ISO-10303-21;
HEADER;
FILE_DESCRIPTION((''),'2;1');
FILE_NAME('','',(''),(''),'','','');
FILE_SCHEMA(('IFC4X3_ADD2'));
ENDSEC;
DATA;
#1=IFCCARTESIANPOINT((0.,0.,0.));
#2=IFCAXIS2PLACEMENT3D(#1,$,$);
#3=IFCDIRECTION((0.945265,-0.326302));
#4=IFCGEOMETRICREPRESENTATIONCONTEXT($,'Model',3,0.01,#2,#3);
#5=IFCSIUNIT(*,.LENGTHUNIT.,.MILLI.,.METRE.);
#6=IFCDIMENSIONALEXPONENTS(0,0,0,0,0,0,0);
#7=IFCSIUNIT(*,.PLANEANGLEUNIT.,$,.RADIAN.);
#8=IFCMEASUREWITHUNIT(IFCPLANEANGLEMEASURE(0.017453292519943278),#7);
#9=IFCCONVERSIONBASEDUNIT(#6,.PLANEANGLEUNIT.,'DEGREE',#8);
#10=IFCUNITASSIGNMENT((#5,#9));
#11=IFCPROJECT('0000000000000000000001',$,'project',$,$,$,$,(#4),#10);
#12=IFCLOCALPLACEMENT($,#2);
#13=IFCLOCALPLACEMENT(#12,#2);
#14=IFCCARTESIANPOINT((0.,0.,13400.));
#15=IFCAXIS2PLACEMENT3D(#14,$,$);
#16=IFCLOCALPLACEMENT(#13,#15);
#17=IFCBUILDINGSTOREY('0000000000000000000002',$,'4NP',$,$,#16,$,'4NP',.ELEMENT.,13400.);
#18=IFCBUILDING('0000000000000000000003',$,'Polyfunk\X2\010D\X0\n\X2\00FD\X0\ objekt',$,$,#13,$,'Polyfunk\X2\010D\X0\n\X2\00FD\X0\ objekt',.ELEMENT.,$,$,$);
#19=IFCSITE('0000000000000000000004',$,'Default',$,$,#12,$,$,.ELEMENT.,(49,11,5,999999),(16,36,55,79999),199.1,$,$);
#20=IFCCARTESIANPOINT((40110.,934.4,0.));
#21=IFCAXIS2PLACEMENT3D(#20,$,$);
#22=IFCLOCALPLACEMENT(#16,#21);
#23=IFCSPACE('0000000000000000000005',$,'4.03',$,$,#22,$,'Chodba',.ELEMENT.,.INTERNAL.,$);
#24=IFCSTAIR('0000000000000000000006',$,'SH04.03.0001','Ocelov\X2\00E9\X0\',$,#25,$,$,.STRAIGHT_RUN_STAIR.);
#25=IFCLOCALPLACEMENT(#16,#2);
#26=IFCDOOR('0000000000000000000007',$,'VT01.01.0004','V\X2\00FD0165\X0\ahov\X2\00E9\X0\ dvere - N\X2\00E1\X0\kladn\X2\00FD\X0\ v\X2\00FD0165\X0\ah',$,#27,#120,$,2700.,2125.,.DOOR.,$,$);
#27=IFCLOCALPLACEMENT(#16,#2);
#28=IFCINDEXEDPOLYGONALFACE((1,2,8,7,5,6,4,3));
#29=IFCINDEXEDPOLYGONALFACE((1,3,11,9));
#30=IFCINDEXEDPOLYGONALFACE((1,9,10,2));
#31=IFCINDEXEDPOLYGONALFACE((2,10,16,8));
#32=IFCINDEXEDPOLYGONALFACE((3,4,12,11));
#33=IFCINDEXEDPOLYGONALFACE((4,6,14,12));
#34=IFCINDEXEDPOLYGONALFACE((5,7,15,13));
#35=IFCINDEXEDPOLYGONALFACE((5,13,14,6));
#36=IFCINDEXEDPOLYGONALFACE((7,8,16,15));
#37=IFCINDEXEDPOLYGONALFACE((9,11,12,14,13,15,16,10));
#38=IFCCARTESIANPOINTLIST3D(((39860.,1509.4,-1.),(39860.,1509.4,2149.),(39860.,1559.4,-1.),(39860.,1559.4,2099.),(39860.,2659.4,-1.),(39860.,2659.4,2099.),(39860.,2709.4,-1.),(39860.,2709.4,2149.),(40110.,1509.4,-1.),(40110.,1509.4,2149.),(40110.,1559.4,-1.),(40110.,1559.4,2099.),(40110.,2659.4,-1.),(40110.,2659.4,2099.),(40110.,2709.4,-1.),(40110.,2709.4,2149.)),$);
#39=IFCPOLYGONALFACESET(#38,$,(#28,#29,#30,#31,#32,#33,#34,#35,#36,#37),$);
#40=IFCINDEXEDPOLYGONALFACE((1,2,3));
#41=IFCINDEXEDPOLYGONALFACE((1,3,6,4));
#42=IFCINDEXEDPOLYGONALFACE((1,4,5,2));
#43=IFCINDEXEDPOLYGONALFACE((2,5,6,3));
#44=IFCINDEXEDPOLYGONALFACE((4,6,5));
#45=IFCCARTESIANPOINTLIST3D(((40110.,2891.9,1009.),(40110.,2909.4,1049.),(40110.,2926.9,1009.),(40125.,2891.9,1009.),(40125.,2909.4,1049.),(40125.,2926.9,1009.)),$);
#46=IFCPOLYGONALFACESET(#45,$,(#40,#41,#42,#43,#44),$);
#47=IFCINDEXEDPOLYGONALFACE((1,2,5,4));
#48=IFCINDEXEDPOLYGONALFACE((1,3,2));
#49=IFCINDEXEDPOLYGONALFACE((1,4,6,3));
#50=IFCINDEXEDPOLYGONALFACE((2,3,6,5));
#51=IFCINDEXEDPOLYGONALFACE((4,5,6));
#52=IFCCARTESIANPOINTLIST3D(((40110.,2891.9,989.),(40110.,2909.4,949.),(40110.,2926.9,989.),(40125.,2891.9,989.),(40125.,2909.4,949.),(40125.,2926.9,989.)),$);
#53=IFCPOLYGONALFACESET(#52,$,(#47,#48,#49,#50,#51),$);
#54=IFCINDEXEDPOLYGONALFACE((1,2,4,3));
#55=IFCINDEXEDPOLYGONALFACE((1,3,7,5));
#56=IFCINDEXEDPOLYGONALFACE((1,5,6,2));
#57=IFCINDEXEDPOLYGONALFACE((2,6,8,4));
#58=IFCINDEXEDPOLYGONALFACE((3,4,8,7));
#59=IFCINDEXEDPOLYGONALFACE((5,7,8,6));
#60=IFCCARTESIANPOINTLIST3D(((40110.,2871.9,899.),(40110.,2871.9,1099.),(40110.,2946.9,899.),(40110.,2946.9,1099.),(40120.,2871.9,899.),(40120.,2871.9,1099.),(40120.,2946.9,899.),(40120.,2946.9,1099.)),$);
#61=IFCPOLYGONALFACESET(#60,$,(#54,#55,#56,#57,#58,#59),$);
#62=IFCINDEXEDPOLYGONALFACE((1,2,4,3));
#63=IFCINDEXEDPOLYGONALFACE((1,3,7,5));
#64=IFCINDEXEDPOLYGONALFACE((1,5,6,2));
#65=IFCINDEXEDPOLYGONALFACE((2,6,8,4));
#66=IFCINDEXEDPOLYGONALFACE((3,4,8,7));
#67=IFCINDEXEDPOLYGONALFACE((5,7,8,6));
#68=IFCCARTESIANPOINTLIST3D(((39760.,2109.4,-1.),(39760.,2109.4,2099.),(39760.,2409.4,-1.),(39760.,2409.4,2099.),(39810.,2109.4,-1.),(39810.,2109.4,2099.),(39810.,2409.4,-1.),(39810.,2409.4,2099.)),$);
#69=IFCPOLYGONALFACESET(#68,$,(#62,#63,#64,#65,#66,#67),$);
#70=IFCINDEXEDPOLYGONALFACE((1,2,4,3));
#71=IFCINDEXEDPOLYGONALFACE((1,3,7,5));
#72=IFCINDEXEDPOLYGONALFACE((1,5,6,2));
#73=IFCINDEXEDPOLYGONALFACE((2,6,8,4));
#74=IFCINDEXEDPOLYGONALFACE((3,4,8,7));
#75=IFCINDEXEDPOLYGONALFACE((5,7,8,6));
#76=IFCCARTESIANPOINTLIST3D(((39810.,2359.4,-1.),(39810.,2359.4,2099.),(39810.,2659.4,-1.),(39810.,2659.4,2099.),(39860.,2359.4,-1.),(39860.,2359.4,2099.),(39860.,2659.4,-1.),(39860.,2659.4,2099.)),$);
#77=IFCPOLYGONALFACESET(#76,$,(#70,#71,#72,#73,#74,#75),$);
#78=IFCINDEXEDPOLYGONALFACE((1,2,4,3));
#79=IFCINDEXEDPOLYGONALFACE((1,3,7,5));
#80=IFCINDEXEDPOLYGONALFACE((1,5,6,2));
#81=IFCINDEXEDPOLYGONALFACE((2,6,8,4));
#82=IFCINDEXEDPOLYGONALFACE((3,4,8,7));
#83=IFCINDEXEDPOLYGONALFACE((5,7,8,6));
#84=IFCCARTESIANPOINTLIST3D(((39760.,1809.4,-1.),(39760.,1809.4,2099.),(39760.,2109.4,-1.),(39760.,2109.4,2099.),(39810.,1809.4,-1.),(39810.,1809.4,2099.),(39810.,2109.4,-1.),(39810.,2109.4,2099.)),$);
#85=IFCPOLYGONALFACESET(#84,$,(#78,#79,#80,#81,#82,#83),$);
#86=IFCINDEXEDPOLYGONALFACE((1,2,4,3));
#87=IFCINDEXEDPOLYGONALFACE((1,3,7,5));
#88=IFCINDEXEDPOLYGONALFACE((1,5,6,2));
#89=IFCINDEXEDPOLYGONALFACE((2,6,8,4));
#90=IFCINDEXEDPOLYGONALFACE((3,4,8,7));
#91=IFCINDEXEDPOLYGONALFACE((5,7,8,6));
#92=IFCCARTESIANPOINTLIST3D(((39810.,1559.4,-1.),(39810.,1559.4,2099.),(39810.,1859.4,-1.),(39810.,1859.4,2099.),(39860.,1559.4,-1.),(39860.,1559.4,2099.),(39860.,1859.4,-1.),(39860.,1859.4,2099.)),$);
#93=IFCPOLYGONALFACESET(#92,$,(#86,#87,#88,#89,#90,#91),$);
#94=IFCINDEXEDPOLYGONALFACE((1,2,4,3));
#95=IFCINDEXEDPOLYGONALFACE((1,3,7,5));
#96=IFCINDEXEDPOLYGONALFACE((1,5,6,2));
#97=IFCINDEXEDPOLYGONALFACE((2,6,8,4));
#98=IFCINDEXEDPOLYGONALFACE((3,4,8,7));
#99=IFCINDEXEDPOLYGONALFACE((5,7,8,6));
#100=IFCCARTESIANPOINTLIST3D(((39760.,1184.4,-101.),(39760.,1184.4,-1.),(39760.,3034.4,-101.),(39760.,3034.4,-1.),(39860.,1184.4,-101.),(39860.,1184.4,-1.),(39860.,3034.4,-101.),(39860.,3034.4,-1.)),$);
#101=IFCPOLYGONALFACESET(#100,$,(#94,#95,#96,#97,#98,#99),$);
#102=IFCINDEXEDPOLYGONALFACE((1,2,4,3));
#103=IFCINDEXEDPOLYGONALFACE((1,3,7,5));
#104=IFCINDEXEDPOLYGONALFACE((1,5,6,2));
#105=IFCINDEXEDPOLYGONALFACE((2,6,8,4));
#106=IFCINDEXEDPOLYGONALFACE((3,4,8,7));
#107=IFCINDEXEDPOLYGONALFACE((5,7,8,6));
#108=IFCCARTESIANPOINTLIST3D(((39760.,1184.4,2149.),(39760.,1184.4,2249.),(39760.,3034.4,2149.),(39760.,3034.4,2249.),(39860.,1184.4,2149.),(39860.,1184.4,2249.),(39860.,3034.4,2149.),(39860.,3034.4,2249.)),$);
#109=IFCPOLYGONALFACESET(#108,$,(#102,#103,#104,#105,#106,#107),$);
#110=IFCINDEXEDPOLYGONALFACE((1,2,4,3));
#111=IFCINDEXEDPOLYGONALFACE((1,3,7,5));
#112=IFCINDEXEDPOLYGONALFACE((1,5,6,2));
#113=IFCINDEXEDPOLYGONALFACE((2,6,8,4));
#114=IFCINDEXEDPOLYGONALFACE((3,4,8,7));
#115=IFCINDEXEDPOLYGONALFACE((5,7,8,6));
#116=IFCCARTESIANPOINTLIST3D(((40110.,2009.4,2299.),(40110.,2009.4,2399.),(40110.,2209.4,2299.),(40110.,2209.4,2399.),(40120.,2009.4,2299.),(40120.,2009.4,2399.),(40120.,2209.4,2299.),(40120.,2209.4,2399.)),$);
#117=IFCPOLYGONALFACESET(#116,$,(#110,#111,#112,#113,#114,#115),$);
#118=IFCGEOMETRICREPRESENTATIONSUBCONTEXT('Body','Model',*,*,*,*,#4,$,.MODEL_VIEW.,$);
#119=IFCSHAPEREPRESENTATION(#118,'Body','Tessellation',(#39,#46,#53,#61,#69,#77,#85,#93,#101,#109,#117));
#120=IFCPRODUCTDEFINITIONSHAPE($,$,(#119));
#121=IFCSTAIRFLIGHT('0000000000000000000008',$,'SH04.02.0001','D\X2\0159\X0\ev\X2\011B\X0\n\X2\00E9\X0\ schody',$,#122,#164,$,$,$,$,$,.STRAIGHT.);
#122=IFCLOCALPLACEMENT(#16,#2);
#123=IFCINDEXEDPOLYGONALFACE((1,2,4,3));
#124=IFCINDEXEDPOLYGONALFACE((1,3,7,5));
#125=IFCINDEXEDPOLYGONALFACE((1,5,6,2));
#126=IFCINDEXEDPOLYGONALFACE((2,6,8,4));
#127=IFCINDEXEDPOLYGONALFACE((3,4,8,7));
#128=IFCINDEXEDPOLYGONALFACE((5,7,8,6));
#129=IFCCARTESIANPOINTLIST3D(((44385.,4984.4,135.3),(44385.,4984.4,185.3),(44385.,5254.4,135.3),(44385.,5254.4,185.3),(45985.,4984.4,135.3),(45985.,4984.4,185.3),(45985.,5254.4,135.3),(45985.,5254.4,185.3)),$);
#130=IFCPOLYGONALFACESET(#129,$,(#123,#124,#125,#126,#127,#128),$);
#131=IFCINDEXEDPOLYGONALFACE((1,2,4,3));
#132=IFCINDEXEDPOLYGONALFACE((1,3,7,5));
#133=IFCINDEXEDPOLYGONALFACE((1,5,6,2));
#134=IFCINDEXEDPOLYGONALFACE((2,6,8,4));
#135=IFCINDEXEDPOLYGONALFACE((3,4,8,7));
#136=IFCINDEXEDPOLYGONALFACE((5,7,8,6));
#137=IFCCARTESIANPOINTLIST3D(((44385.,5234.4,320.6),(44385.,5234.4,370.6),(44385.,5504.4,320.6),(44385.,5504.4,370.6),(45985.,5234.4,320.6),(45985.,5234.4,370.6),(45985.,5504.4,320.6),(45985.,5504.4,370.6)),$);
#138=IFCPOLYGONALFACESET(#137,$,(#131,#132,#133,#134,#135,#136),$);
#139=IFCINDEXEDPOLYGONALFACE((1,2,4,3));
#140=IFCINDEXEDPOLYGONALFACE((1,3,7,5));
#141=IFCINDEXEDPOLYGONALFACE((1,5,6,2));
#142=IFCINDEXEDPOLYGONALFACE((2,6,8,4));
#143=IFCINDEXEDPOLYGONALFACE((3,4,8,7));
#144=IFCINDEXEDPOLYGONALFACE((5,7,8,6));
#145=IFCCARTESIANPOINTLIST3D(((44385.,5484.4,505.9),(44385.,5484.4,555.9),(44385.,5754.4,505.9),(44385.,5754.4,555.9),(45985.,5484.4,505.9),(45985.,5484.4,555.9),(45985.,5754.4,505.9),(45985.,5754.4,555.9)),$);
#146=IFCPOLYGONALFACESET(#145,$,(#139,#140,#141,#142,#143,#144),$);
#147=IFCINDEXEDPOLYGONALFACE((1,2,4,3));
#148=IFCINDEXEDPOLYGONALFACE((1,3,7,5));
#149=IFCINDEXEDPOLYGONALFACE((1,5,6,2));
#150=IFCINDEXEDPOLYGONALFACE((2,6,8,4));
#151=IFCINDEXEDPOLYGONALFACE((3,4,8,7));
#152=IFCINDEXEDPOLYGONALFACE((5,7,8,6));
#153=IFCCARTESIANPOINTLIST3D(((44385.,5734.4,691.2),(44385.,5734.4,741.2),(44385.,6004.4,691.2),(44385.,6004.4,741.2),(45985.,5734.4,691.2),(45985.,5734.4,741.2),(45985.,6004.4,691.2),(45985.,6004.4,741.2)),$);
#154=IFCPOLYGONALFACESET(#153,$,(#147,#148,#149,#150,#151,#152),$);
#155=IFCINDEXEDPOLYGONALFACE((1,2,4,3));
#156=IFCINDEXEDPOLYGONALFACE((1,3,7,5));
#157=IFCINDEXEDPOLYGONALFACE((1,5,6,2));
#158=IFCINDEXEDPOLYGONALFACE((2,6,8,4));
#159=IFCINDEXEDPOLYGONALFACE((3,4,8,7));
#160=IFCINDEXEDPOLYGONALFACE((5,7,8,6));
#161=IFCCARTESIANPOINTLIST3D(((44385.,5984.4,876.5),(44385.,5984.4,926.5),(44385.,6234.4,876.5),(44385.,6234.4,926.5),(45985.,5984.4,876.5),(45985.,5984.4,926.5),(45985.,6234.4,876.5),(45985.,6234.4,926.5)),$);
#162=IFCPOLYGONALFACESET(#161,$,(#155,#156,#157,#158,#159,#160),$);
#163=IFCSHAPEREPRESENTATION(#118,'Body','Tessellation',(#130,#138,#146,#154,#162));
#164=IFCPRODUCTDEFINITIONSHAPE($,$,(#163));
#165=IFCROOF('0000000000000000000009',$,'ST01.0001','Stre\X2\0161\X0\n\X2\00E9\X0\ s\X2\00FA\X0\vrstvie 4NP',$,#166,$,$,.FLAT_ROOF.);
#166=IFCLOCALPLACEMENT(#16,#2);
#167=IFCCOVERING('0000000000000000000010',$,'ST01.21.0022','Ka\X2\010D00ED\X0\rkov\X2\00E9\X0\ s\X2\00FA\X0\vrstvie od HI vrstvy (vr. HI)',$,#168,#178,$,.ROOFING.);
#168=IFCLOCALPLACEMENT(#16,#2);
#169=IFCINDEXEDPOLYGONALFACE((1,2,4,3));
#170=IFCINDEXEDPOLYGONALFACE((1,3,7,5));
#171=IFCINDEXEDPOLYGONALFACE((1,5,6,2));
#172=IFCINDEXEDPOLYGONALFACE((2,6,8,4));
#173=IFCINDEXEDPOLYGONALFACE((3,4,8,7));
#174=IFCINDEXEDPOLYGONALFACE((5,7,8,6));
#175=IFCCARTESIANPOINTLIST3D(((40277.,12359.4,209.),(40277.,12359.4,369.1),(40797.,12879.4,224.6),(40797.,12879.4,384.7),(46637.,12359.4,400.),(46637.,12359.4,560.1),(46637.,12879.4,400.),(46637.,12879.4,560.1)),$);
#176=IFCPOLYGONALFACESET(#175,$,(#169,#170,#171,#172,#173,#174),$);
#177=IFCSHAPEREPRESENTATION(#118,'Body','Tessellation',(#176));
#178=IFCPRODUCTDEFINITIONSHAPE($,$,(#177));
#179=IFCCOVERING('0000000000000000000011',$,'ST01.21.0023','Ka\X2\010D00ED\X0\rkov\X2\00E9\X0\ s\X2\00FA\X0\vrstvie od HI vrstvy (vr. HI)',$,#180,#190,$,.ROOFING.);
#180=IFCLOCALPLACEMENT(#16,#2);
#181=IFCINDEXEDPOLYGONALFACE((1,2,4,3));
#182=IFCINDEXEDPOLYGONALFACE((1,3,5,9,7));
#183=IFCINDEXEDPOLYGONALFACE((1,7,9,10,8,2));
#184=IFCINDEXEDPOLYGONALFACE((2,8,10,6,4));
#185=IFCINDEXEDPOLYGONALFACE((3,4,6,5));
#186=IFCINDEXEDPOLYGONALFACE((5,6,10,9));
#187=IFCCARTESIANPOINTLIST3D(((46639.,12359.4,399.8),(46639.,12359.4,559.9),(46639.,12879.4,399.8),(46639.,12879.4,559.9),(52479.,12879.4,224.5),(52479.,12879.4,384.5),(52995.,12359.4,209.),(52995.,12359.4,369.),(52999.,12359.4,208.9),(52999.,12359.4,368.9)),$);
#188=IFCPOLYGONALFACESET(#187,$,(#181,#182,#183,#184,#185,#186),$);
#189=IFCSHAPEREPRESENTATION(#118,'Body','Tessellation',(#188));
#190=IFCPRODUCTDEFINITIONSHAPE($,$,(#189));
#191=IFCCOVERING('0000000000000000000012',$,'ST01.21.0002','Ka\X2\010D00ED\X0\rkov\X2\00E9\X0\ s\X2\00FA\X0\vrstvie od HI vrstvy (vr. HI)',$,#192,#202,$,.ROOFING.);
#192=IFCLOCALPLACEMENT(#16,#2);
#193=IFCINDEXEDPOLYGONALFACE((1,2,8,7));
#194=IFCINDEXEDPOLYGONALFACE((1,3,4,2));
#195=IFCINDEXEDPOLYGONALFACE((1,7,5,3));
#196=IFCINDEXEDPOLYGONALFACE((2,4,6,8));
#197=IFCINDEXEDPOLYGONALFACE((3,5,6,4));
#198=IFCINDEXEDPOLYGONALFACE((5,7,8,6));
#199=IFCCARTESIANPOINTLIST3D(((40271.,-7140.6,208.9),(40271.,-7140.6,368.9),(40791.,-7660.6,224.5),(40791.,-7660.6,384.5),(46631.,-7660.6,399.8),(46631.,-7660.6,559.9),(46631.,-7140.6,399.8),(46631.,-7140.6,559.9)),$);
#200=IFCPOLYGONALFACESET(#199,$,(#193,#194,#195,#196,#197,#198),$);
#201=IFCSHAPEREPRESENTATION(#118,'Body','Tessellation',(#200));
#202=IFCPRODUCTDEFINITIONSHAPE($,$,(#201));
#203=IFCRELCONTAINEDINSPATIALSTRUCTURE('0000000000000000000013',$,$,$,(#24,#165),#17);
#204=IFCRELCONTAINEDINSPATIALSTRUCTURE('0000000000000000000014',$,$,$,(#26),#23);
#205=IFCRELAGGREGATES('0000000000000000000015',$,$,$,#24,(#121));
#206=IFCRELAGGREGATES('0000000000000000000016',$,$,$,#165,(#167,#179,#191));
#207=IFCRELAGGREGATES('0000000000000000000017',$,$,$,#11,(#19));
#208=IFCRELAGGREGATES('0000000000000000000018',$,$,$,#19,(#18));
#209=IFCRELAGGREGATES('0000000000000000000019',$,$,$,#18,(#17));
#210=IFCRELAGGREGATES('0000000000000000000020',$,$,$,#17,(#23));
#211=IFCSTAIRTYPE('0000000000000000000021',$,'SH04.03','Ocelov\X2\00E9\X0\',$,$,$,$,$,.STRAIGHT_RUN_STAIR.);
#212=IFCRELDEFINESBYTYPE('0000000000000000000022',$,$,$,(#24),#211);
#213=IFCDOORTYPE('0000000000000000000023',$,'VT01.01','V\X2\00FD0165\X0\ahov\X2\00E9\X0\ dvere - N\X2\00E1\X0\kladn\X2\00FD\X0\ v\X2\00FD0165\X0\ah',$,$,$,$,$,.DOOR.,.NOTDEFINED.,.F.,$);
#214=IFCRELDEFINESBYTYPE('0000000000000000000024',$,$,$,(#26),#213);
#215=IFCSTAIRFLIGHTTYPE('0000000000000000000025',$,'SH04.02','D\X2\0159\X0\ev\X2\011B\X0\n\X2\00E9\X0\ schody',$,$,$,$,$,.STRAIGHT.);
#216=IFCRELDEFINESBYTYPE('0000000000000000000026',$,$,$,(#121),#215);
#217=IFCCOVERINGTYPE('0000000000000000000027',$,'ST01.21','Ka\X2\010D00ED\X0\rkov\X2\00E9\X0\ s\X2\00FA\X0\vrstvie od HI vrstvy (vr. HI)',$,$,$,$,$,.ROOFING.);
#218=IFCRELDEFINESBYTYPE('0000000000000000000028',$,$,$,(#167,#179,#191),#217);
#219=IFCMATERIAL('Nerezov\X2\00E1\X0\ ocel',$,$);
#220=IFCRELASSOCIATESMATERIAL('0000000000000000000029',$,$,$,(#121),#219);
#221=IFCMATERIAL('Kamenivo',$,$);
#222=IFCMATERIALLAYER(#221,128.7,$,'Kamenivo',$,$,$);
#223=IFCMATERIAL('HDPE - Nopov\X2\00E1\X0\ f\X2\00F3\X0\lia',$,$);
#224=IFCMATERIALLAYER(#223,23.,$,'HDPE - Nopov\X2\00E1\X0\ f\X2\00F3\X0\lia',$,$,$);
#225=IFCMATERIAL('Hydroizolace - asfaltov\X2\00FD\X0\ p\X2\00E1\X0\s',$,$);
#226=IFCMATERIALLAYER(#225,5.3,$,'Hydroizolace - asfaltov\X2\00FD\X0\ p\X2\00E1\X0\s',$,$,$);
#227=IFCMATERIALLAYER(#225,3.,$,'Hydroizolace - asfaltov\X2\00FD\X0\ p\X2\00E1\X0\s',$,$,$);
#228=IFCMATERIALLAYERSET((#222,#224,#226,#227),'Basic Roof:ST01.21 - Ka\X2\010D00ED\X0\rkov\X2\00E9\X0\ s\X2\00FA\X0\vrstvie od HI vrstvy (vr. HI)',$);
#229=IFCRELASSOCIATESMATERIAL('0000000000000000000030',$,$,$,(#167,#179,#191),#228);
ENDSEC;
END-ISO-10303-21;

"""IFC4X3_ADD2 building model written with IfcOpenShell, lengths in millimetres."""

from ifc_helpers import new_model, entity, si_unit, converted_unit, direction, frame, frame_2d, origin, origin_2d_with_axis, place, context, subcontext, project, spatial, polyline, rectangle, outline, extrude, source, transform, mapped, material, layer, layer_set, type_object, type_shapes, element, aggregate, save


model = new_model("IFC4X3_ADD2")

# Units and contexts
model_context = context("Model", 3, precision=0.01, world=origin(), true_north=direction((0.945265, -0.326302)))
body_context = subcontext(model_context, "Body", "Model", "MODEL_VIEW")
ifc_project = project(units=[si_unit("LENGTHUNIT", "METRE", prefix="MILLI"), converted_unit("PLANEANGLEUNIT", "DEGREE", entity("IfcPlaneAngleMeasure", 0.017453292519943278), si_unit("PLANEANGLEUNIT", "RADIAN"), dimensions=[0, 0, 0, 0, 0, 0, 0])], contexts=[model_context])

# Site, building, storey
site_placement = place(None, origin())
site = spatial("IfcSite", under=ifc_project, at=site_placement, Name="Default", CompositionType="ELEMENT", RefLatitude=(49, 11, 5, 999999), RefLongitude=(16, 36, 55, 79999), RefElevation=199.1)
building_placement = place(site_placement, origin())
building = spatial("IfcBuilding", under=site, at=building_placement, Name="Polyfunkčný objekt", LongName="Polyfunkčný objekt", CompositionType="ELEMENT")
storey_placement = place(building_placement, frame((0.0, 0.0, 13400.0)))
storey = spatial("IfcBuildingStorey", under=building, at=storey_placement, Name="4NP", LongName="4NP", CompositionType="ELEMENT", Elevation=13400.0)

# Shared definitions
ifc_material_1 = material(Name="Nerezová ocel")

# Stair
stair_type = type_object("IfcStairType", Name="SH04.03", Description="Ocelové", PredefinedType="STRAIGHT_RUN_STAIR")
stair_placement = place(storey_placement, origin())
stair = element("IfcStair", 1, at=stair_placement, inside=storey, type_object=stair_type, Name="SH04.03.0001", Description="Ocelové", PredefinedType="STRAIGHT_RUN_STAIR")

# Shared definitions
space_placement = place(storey_placement, frame((40110.0, 934.4, 0.0)))
space = spatial("IfcSpace", under=storey, at=space_placement, Name="4.03", LongName="Chodba", CompositionType="ELEMENT", PredefinedType="INTERNAL")

# Door
door_type_1 = type_object("IfcDoorType", Name="VT01.01", Description="Výťahové dvere - Nákladný výťah", OperationType="NOTDEFINED", ParameterTakesPrecedence=False, PredefinedType="DOOR")
shared_shape_1 = source(origin(), body_context, "Body", "SweptSolid", [
    extrude(outline(polyline([(-1087.5, -600.0), (1062.5, -600.0), (1062.5, -550.0), (-1037.5, -550.0), (-1037.5, 550.0), (1062.5, 550.0), (1062.5, 600.0), (-1087.5, 600.0), (-1087.5, -600.0)])), frame((600.0, 0.0, 1062.5), z_axis=(0.0, 1.0, 0.0), x_axis=(0.0, 0.0, -1.0)), (0.0, 0.0, 1.0), 250.0),
    extrude(outline(polyline([(-24.4, -10.7), (19.2, -10.7), (5.2, 21.4), (-24.4, -10.7)])), frame((1400.0, -15.0, 1023.3), z_axis=(0.0, 1.0, 0.0), x_axis=(0.400819, 0.0, -0.916157)), (0.0, 0.0, 1.0), 15.0),
    extrude(outline(polyline([(-24.4, -10.7), (19.2, -10.7), (5.2, 21.4), (-24.4, -10.7)])), frame((1400.0, -15.0, 976.7), z_axis=(0.0, 1.0, 0.0), x_axis=(-0.400819, 0.0, 0.916157)), (0.0, 0.0, 1.0), 15.0),
    extrude(rectangle(XDim=10.0, YDim=75.0, at=frame_2d((0.0, 0.0), x_axis=(1.0, 0.0))), frame((1400.0, -5.0, 900.0), z_axis=(0.0, 0.0, 1.0), x_axis=(0.0, 1.0, 0.0)), (0.0, 0.0, 1.0), 200.0),
    extrude(rectangle(XDim=50.0, YDim=300.0, at=origin_2d_with_axis()), frame((750.0, 325.0, 0.0), z_axis=(0.0, 0.0, 1.0), x_axis=(0.0, -1.0, 0.0)), (0.0, 0.0, 1.0), 2100.0),
    extrude(rectangle(XDim=50.0, YDim=300.0, at=frame_2d((0.0, 0.0), x_axis=(1.0, 0.0))), frame((1000.0, 275.0, 0.0), z_axis=(0.0, 0.0, 1.0), x_axis=(0.0, -1.0, 0.0)), (0.0, 0.0, 1.0), 2100.0),
    extrude(rectangle(XDim=300.0, YDim=50.0, at=frame_2d((0.0, 0.0), x_axis=(1.0, 0.0))), frame((450.0, 325.0, 0.0), z_axis=(0.0, 0.0, 1.0), x_axis=(-1.0, 0.0, 0.0)), (0.0, 0.0, 1.0), 2100.0),
    extrude(rectangle(XDim=300.0, YDim=50.0, at=frame_2d((0.0, 0.0), x_axis=(1.0, 0.0))), frame((200.0, 275.0, 0.0), z_axis=(0.0, 0.0, 1.0), x_axis=(-1.0, 0.0, 0.0)), (0.0, 0.0, 1.0), 2100.0),
    extrude(rectangle(XDim=1850.0, YDim=100.0, at=frame_2d((0.0, 0.0), x_axis=(1.0, 0.0))), frame((600.0, 300.0, -100.0), z_axis=(0.0, 0.0, 1.0), x_axis=(-1.0, 0.0, 0.0)), (0.0, 0.0, 1.0), 100.0),
    extrude(rectangle(XDim=1850.0, YDim=100.0, at=frame_2d((0.0, 0.0), x_axis=(1.0, 0.0))), frame((600.0, 300.0, 2150.0), z_axis=(0.0, 0.0, 1.0), x_axis=(-1.0, 0.0, 0.0)), (0.0, 0.0, 1.0), 100.0),
    extrude(rectangle(XDim=10.0, YDim=200.0, at=frame_2d((0.0, 0.0), x_axis=(1.0, 0.0))), frame((600.0, -5.0, 2300.0), z_axis=(0.0, 0.0, 1.0), x_axis=(0.0, 1.0, 0.0)), (0.0, 0.0, 1.0), 100.0),
])
type_shapes(door_type_1, [shared_shape_1])
door_1_placement = place(storey_placement, frame((40110.0, 1509.4, -1.0), z_axis=(0.0, 0.0, 1.0), x_axis=(0.0, 1.0, 0.0)))
element("IfcDoor", 2, at=door_1_placement, inside=space, type_object=door_type_1, Name="VT01.01.0004", Description="Výťahové dvere - Nákladný výťah", OverallHeight=2700.0, OverallWidth=2125.0, PredefinedType="DOOR", context=body_context, shape_type="MappedRepresentation", body=[
    mapped(shared_shape_1, transform((0.0, 0.0, 0.0), scale=1.0)),
])

# Stair flight
stair_flight_type = type_object("IfcStairFlightType", Name="SH04.02", Description="Dřevěné schody", PredefinedType="STRAIGHT")
stair_flight_placement = place(stair_placement, frame((44385.0, 4984.4, 0.0)))
stair_flight = element("IfcStairFlight", 3, at=stair_flight_placement, type_object=stair_flight_type, material=ifc_material_1, Name="SH04.02.0001", Description="Dřevěné schody", PredefinedType="STRAIGHT", context=body_context, shape_type="SweptSolid", body=[
    extrude(rectangle(XDim=270.0, YDim=1600.0, at=origin_2d_with_axis()), frame((800.0, 135.0, 135.3), z_axis=(0.0, 0.0, 1.0), x_axis=(0.0, -1.0, 0.0)), (0.0, 0.0, 1.0), 50.0),
    extrude(rectangle(XDim=270.0, YDim=1600.0, at=origin_2d_with_axis()), frame((800.0, 385.0, 320.6), z_axis=(0.0, 0.0, 1.0), x_axis=(0.0, -1.0, 0.0)), (0.0, 0.0, 1.0), 50.0),
    extrude(rectangle(XDim=270.0, YDim=1600.0, at=origin_2d_with_axis()), frame((800.0, 635.0, 505.9), z_axis=(0.0, 0.0, 1.0), x_axis=(0.0, -1.0, 0.0)), (0.0, 0.0, 1.0), 50.0),
    extrude(rectangle(XDim=270.0, YDim=1600.0, at=origin_2d_with_axis()), frame((800.0, 885.0, 691.2), z_axis=(0.0, 0.0, 1.0), x_axis=(0.0, -1.0, 0.0)), (0.0, 0.0, 1.0), 50.0),
    extrude(rectangle(XDim=250.0, YDim=1600.0, at=origin_2d_with_axis()), frame((800.0, 1125.0, 876.5), z_axis=(0.0, 0.0, 1.0), x_axis=(0.0, -1.0, 0.0)), (0.0, 0.0, 1.0), 50.0),
])
aggregate(stair, [stair_flight])

# Roof, coverings
roof = element("IfcRoof", 4, inside=storey, Name="ST01.0001", Description="Strešné súvrstvie 4NP", PredefinedType="FLAT_ROOF")
ifc_material_2 = material(Name="Kamenivo")
ifc_layer_1 = layer(ifc_material_2, 128.7, Name="Kamenivo")
ifc_material_3 = material(Name="HDPE - Nopová fólia")
ifc_layer_2 = layer(ifc_material_3, 23.0, Name="HDPE - Nopová fólia")
ifc_material_4 = material(Name="Hydroizolace - asfaltový pás")
ifc_layer_3 = layer(ifc_material_4, 5.3, Name="Hydroizolace - asfaltový pás")
ifc_layer_4 = layer(ifc_material_4, 3.0, Name="Hydroizolace - asfaltový pás")
ifc_layer_set_1 = layer_set([ifc_layer_1, ifc_layer_2, ifc_layer_3, ifc_layer_4], Name="Basic Roof:ST01.21 - Kačírkové súvrstvie od HI vrstvy (vr. HI)")
covering_type = type_object("IfcCoveringType", Name="ST01.21", Description="Kačírkové súvrstvie od HI vrstvy (vr. HI)", PredefinedType="ROOFING")
placement_1 = place(storey_placement, frame((40277.0, 12359.4, 209.0)))
covering_1_placement = place(placement_1, origin())
covering_1 = element("IfcCovering", 5, at=covering_1_placement, type_object=covering_type, material=ifc_layer_set_1, Name="ST01.21.0022", Description="Kačírkové súvrstvie od HI vrstvy (vr. HI)", PredefinedType="ROOFING", context=body_context, shape_type="SweptSolid", body=[
    extrude(outline(polyline([(-3181.4, -260.0), (3181.4, -260.0), (3181.4, 260.0), (-2661.2, 260.0), (-3181.4, -260.0)])), frame((3180.0, 260.0, 95.5), z_axis=(-0.030015, 0.0, 0.999549), x_axis=(0.999549, 0.0, 0.030015)), (0.030015, 0.0, 0.999549), 160.1),
])
placement_2 = place(storey_placement, frame((46639.0, 12359.4, 208.9)))
covering_2_placement = place(placement_2, origin())
covering_2 = element("IfcCovering", 6, at=covering_2_placement, type_object=covering_type, material=ifc_layer_set_1, Name="ST01.21.0023", Description="Kačírkové súvrstvie od HI vrstvy (vr. HI)", PredefinedType="ROOFING", context=body_context, shape_type="SweptSolid", body=[
    extrude(outline(polyline([(2661.2, 260.0), (-3181.4, 260.0), (-3181.4, -260.0), (3177.4, -260.0), (3181.4, -260.0), (2661.2, 260.0)])), frame((3180.0, 260.0, 95.5), z_axis=(0.030015, 0.0, 0.999549), x_axis=(0.999549, 0.0, -0.030015)), (-0.030015, 0.0, 0.999549), 160.1),
])
placement_3 = place(storey_placement, frame((40271.0, -7660.6, 208.9)))
covering_3_placement = place(placement_3, origin())
covering_3 = element("IfcCovering", 7, at=covering_3_placement, type_object=covering_type, material=ifc_layer_set_1, Name="ST01.21.0002", Description="Kačírkové súvrstvie od HI vrstvy (vr. HI)", PredefinedType="ROOFING", context=body_context, shape_type="SweptSolid", body=[
    extrude(outline(polyline([(-2661.2, -260.0), (3181.4, -260.0), (3181.4, 260.0), (-3181.4, 260.0), (-2661.2, -260.0)])), frame((3180.0, 260.0, 95.5), z_axis=(-0.030015, 0.0, 0.999549), x_axis=(0.999549, 0.0, 0.030015)), (0.030015, 0.0, 0.999549), 160.1),
])
aggregate(roof, [covering_1, covering_2, covering_3])

save(model, "model.ifc")
